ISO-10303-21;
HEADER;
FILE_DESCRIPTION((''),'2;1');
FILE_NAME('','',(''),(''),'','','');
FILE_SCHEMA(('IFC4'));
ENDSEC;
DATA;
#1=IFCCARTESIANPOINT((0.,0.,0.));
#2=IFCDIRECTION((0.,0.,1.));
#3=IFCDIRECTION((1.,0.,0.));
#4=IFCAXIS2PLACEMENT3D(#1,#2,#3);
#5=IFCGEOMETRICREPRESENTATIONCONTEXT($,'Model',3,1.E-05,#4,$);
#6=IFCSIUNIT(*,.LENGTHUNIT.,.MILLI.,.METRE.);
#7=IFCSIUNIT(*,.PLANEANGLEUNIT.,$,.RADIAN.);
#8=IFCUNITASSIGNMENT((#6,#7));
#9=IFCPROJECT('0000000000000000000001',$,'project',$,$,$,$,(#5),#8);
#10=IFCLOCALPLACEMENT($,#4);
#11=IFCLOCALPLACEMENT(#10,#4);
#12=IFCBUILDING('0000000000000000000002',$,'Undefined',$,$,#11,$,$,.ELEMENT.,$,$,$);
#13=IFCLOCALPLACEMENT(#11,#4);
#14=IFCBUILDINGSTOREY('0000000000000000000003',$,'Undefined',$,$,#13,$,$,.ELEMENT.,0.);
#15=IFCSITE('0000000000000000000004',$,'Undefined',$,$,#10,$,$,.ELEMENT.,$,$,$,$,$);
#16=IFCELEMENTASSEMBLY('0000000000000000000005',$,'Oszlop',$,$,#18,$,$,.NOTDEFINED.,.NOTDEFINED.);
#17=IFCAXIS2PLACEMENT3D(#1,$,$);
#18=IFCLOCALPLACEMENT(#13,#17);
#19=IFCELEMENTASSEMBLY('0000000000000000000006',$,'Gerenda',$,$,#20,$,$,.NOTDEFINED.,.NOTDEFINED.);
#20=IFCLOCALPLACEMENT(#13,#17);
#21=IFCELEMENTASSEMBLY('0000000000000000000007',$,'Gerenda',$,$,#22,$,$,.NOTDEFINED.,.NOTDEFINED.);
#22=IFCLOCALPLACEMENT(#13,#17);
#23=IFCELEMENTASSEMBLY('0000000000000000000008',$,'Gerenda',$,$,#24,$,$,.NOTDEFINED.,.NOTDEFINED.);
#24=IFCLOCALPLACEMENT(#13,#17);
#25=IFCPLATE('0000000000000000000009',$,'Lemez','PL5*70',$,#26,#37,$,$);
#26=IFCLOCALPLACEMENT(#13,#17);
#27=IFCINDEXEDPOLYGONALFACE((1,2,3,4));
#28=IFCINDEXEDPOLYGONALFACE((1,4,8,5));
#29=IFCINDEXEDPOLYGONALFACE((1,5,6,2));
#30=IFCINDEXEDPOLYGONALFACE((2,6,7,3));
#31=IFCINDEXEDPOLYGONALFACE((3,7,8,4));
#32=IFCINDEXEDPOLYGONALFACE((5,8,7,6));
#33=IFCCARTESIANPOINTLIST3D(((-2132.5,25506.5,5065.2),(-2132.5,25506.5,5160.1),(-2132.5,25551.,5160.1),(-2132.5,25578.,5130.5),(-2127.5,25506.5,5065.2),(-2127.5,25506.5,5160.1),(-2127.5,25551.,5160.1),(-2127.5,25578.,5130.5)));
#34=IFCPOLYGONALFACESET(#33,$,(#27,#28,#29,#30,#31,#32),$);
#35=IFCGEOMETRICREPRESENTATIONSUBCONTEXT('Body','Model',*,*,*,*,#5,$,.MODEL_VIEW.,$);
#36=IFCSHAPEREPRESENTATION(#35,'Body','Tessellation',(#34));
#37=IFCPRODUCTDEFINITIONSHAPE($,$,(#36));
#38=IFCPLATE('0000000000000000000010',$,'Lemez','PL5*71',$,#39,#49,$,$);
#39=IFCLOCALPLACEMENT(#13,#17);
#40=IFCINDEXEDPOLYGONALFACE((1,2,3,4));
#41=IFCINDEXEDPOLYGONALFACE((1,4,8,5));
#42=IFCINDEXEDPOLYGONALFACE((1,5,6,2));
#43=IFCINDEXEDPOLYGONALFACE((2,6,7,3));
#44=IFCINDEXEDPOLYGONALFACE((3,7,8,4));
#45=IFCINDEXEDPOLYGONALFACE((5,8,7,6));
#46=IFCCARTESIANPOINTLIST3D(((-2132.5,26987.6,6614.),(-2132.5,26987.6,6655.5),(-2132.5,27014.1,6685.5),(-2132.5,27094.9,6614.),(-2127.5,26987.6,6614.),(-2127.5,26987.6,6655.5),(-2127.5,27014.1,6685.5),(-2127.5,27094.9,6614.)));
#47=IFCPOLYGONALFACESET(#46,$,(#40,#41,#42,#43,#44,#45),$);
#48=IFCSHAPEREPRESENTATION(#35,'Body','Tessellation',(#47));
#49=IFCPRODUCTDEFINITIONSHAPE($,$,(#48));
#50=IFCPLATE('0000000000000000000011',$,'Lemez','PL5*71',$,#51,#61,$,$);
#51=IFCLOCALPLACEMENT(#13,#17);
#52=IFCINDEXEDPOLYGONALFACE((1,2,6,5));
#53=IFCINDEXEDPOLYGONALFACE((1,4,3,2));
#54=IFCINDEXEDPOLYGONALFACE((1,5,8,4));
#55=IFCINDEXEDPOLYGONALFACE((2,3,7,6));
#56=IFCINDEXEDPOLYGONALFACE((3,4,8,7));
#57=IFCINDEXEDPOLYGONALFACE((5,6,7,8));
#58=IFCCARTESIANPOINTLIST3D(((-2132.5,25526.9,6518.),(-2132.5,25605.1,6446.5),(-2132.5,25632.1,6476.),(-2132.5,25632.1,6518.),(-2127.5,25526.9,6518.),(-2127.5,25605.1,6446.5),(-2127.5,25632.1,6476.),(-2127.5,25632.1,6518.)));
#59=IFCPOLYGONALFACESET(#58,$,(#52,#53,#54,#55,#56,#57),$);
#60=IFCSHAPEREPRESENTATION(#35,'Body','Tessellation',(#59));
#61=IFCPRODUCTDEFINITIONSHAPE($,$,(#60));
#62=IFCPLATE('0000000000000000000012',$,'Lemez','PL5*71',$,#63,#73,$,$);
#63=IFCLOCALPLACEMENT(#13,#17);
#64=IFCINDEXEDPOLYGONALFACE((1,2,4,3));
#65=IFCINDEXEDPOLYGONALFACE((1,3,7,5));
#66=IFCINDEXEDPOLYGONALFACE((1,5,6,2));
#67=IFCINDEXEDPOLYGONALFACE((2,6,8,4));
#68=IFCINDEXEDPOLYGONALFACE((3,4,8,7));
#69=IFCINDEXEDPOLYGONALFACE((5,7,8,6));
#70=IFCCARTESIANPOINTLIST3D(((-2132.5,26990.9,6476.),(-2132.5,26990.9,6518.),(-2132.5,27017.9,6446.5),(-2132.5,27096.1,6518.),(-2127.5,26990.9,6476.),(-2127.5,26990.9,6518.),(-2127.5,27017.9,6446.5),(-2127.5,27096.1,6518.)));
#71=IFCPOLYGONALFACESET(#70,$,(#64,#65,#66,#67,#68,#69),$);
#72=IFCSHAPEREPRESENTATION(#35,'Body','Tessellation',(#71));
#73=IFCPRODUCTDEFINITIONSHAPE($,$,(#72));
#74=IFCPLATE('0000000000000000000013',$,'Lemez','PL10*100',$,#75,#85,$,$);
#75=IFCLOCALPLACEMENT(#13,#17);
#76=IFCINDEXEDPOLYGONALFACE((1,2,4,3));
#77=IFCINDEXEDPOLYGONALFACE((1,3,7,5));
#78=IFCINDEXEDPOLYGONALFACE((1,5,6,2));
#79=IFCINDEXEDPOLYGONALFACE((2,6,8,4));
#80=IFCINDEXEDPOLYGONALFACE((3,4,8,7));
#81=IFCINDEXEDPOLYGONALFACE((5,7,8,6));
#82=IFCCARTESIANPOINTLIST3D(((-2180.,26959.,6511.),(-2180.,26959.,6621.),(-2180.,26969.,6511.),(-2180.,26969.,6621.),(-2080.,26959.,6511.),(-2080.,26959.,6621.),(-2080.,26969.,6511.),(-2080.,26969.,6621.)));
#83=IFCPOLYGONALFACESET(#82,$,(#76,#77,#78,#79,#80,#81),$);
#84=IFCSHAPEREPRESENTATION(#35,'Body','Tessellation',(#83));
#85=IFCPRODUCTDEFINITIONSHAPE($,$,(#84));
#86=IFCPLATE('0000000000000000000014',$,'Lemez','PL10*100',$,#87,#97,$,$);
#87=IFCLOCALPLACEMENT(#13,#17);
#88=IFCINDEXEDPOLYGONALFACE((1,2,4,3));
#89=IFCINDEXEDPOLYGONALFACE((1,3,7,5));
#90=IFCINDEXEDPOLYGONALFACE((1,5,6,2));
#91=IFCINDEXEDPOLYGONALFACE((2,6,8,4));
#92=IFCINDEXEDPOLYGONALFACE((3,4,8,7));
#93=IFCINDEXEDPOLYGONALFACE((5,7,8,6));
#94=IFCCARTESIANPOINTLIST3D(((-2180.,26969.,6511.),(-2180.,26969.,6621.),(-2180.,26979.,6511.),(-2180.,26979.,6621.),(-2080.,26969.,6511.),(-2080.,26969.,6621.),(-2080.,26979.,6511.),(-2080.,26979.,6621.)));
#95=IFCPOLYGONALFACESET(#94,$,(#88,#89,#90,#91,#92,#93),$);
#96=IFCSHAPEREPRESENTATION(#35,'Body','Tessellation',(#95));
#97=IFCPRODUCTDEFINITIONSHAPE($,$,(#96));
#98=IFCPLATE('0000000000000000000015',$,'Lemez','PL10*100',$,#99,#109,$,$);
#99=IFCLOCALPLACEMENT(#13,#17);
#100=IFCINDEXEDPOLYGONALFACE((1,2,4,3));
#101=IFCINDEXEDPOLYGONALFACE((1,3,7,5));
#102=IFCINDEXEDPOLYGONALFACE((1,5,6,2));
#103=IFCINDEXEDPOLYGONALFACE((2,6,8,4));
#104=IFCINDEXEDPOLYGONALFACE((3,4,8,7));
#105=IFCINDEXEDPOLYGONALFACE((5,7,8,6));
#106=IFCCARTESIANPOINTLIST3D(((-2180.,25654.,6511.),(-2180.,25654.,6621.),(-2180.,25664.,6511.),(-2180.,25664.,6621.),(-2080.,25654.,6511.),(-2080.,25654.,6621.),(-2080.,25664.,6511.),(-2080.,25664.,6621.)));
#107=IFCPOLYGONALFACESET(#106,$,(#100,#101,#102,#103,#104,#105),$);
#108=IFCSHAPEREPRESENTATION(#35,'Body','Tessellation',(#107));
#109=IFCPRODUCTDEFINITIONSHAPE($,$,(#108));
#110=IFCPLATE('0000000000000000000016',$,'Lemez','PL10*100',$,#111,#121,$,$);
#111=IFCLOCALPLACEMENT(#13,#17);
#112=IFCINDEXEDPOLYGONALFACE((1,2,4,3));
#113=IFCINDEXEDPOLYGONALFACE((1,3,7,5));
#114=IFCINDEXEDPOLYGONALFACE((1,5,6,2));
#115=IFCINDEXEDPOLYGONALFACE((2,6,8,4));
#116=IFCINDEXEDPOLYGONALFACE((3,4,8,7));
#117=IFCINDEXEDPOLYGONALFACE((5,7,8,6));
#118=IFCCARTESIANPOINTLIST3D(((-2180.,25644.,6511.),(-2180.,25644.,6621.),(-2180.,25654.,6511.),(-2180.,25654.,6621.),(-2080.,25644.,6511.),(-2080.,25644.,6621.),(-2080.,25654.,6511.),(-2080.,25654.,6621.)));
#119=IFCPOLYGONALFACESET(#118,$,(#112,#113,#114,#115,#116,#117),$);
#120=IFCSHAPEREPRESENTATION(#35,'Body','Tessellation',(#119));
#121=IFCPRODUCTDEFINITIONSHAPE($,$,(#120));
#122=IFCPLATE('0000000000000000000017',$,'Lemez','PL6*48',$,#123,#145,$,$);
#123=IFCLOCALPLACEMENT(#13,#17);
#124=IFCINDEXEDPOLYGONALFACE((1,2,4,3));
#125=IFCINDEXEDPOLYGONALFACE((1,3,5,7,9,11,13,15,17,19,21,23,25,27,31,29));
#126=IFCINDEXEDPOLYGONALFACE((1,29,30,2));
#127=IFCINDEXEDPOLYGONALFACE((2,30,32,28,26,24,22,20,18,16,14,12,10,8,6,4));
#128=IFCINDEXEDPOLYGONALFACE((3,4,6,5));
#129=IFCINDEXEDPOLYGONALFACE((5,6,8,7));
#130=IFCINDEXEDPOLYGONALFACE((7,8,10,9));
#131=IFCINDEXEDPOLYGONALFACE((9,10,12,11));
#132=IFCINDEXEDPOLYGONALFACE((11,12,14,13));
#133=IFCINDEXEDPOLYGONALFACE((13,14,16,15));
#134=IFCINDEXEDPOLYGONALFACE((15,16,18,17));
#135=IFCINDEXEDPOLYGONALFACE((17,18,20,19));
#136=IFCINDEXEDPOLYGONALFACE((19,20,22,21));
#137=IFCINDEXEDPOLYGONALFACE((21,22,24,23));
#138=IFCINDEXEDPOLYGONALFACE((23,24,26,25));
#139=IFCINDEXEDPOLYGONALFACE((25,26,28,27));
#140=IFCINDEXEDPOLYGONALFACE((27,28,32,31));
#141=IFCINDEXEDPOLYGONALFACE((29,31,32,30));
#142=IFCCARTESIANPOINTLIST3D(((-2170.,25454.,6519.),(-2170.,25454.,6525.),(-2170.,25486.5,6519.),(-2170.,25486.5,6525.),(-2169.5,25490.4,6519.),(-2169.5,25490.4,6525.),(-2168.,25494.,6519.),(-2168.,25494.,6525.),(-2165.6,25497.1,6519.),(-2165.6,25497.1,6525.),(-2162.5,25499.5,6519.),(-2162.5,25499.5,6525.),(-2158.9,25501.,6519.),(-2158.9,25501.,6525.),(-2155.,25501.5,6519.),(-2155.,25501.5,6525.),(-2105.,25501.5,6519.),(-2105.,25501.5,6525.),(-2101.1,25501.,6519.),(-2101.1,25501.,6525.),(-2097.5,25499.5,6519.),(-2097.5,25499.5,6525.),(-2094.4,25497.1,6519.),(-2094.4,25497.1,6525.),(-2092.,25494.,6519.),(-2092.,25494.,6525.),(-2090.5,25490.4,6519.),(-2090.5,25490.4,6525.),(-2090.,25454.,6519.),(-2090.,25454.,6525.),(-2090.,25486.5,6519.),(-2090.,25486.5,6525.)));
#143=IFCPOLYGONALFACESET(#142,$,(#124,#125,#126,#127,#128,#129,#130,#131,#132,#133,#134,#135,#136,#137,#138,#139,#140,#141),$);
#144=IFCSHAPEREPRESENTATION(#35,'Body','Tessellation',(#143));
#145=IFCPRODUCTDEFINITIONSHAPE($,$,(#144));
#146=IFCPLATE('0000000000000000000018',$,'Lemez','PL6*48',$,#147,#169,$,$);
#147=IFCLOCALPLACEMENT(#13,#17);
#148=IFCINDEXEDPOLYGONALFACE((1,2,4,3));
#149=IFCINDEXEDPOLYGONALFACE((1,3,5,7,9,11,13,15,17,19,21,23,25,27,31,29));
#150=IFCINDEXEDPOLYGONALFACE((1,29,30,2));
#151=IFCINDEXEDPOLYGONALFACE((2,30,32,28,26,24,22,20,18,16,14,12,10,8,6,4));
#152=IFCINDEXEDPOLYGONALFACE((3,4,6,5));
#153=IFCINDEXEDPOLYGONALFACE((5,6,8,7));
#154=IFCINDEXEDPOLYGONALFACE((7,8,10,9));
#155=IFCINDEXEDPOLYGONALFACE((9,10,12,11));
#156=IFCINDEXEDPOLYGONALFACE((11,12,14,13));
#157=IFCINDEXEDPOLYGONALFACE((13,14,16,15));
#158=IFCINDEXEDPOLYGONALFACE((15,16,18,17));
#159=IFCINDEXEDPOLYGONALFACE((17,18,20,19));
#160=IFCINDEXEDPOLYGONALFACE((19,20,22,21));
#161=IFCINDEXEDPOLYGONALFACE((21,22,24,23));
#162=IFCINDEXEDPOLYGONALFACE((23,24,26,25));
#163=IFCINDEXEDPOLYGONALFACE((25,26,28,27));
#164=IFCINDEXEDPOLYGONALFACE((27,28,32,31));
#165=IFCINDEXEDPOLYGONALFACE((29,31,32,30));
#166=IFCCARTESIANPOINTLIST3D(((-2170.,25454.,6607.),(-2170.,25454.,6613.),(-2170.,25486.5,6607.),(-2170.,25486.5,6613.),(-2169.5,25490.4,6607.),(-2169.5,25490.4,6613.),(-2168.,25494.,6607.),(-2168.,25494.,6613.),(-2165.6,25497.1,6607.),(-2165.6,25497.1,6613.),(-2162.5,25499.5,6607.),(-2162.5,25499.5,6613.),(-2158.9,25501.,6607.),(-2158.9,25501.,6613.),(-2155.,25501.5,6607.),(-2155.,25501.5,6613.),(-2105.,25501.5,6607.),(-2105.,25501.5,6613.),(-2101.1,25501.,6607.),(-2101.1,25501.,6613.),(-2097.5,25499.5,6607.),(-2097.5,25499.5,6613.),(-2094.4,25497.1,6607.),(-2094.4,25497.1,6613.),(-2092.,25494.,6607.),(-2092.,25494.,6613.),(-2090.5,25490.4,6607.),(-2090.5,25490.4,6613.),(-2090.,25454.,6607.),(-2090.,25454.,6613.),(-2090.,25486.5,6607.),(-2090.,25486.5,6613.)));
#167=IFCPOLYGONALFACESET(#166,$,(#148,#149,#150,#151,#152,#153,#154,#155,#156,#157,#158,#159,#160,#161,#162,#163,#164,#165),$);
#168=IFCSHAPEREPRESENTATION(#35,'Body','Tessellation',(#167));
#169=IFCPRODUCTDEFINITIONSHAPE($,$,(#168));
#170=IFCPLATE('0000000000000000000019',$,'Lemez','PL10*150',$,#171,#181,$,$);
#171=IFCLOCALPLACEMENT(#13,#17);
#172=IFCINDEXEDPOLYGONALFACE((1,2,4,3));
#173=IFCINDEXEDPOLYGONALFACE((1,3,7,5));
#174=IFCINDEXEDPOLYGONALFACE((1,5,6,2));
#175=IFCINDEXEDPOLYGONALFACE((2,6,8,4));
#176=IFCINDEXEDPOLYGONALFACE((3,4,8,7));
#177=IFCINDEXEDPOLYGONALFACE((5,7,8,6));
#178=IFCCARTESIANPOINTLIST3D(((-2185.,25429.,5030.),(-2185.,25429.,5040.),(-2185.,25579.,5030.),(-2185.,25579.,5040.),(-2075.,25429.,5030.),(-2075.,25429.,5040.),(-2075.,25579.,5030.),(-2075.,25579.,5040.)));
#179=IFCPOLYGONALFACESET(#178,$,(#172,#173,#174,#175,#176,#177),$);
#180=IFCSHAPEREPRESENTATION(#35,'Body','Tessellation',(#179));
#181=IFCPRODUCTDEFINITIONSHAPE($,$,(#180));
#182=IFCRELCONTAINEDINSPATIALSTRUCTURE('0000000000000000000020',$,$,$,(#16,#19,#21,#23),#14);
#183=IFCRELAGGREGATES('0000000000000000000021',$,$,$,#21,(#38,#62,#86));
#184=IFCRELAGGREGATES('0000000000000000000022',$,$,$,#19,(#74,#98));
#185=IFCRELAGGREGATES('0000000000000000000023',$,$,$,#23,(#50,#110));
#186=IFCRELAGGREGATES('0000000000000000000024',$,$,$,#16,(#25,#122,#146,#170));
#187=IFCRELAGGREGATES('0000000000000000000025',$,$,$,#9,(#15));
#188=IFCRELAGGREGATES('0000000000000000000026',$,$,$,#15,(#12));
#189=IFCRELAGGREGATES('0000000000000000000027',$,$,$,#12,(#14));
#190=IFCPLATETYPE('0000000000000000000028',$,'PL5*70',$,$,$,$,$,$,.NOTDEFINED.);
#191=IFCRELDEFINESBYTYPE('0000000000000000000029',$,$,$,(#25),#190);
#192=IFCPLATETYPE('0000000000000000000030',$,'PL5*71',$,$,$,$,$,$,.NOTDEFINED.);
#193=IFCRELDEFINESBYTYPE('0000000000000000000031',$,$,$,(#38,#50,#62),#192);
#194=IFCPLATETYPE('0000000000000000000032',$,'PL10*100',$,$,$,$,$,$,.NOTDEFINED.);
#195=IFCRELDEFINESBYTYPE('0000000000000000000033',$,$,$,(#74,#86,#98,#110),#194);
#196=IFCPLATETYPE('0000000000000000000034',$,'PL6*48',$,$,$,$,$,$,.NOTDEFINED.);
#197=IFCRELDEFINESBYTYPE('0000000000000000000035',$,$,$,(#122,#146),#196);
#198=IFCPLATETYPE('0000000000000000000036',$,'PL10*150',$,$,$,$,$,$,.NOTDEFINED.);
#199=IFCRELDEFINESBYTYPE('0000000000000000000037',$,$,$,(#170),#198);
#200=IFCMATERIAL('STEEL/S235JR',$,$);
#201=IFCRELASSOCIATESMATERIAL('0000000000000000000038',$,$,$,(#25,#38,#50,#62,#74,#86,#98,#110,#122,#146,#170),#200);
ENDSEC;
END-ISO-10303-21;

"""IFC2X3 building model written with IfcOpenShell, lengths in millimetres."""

from ifc_helpers import new_model, si_unit, frame, frame_2d, origin_with_axes, place, context, subcontext, project, spatial, polyline, circle_curve, parameter, trimmed, segment, composite_curve, outline, extrude, material, type_object, element, aggregate, save


model = new_model("IFC2X3")

# Units and contexts
model_context = context("Model", 3, precision=1e-05, world=origin_with_axes())
body_context = subcontext(model_context, "Body", "Model", "MODEL_VIEW")
ifc_project = project(units=[si_unit("LENGTHUNIT", "METRE", prefix="MILLI"), si_unit("PLANEANGLEUNIT", "RADIAN")], contexts=[model_context])

# Site, building, storey
site_placement = place(None, origin_with_axes())
site = spatial("IfcSite", under=ifc_project, at=site_placement, Name="Undefined", CompositionType="ELEMENT")
building_placement = place(site_placement, origin_with_axes())
building = spatial("IfcBuilding", under=site, at=building_placement, Name="Undefined", CompositionType="ELEMENT")
storey_placement = place(building_placement, origin_with_axes())
storey = spatial("IfcBuildingStorey", under=building, at=storey_placement, Name="Undefined", CompositionType="ELEMENT", Elevation=0.0)

# Element assembly
assembly_1_placement = place(storey_placement, origin_with_axes())
assembly_1 = element("IfcElementAssembly", 1, at=assembly_1_placement, inside=storey, Name="Oszlop", AssemblyPlace="NOTDEFINED", PredefinedType="NOTDEFINED")
ifc_material_1 = material(Name="STEEL/S235JR")

# Element assemblies
assembly_2_placement = place(storey_placement, origin_with_axes())
assembly_2 = element("IfcElementAssembly", 2, at=assembly_2_placement, inside=storey, Name="Gerenda", AssemblyPlace="NOTDEFINED", PredefinedType="NOTDEFINED")
assembly_3_placement = place(storey_placement, origin_with_axes())
assembly_3 = element("IfcElementAssembly", 3, at=assembly_3_placement, inside=storey, Name="Gerenda", AssemblyPlace="NOTDEFINED", PredefinedType="NOTDEFINED")
assembly_4_placement = place(storey_placement, origin_with_axes())
assembly_4 = element("IfcElementAssembly", 4, at=assembly_4_placement, inside=storey, Name="Gerenda", AssemblyPlace="NOTDEFINED", PredefinedType="NOTDEFINED")

# Plates
plate_type_1 = type_object("IfcPlateType", Name="PL5*70", PredefinedType="NOTDEFINED")
plate_1_placement = place(assembly_1_placement, frame((-2130.0, 25506.5, 5160.1), z_axis=(1.0, -0.000004, 0.0), x_axis=(0.0, 0.0, -1.0)))
plate_1 = element("IfcPlate", 5, at=plate_1_placement, type_object=plate_type_1, material=ifc_material_1, Name="Lemez", Description="PL5*70", context=body_context, shape_type="SweptSolid", body=[
    extrude(outline(polyline([(0.0, 0.0), (94.9, 0.0), (29.5, 71.5), (0.0, 44.5), (0.0, 0.0)])), frame((0.0, 0.0, -2.5), z_axis=(0.0, 0.0, 1.0), x_axis=(1.0, 0.0, 0.0)), (0.0, 0.0, 1.0), 5.0),
])
plate_type_2 = type_object("IfcPlateType", Name="PL5*71", PredefinedType="NOTDEFINED")
plate_2_placement = place(assembly_3_placement, frame((-2130.0, 27094.9, 6614.0), z_axis=(-1.0, -0.000003, 0.000002), x_axis=(0.000003, -1.0, 0.0)))
plate_2 = element("IfcPlate", 6, at=plate_2_placement, type_object=plate_type_2, material=ifc_material_1, Name="Lemez", Description="PL5*71", context=body_context, shape_type="SweptSolid", body=[
    extrude(outline(polyline([(0.0, 0.0), (107.3, 0.0), (107.3, 41.5), (80.8, 71.5), (0.0, 0.0)])), frame((0.0, 0.0, -2.5), z_axis=(0.0, 0.0, 1.0), x_axis=(1.0, 0.0, 0.0)), (0.0, 0.0, 1.0), 5.0),
])
plate_3_placement = place(assembly_4_placement, frame((-2130.0, 25526.9, 6518.0), z_axis=(-1.0, -0.000003, 0.000002), x_axis=(-0.000003, 1.0, 0.0)))
plate_3 = element("IfcPlate", 7, at=plate_3_placement, type_object=plate_type_2, material=ifc_material_1, Name="Lemez", Description="PL5*71", context=body_context, shape_type="SweptSolid", body=[
    extrude(outline(polyline([(0.0, 0.0), (105.2, 0.0), (105.2, 42.0), (78.2, 71.5), (0.0, 0.0)])), frame((0.0, 0.0, -2.5), z_axis=(0.0, 0.0, 1.0), x_axis=(1.0, 0.0, 0.0)), (0.0, 0.0, 1.0), 5.0),
])
plate_4_placement = place(assembly_3_placement, frame((-2130.0, 27096.1, 6518.0), z_axis=(1.0, -0.000003, -0.000002), x_axis=(-0.000003, -1.0, 0.0)))
plate_4 = element("IfcPlate", 8, at=plate_4_placement, type_object=plate_type_2, material=ifc_material_1, Name="Lemez", Description="PL5*71", context=body_context, shape_type="SweptSolid", body=[
    extrude(outline(polyline([(0.0, 0.0), (105.2, 0.0), (105.2, 42.0), (78.2, 71.5), (0.0, 0.0)])), frame((0.0, 0.0, -2.5), z_axis=(0.0, 0.0, 1.0), x_axis=(1.0, 0.0, 0.0)), (0.0, 0.0, 1.0), 5.0),
])
plate_type_3 = type_object("IfcPlateType", Name="PL10*100", PredefinedType="NOTDEFINED")
plate_5_placement = place(assembly_2_placement, frame((-2130.0, 26964.0, 6511.0), z_axis=(-0.000003, -1.0, 0.0), x_axis=(0.0, 0.0, 1.0)))
plate_5 = element("IfcPlate", 9, at=plate_5_placement, type_object=plate_type_3, material=ifc_material_1, Name="Lemez", Description="PL10*100", context=body_context, shape_type="SweptSolid", body=[
    extrude(outline(polyline([(0.0, -50.0), (0.0, 50.0), (110.0, 50.0), (110.0, -50.0), (0.0, -50.0)])), frame((0.0, 0.0, -5.0), z_axis=(0.0, 0.0, 1.0), x_axis=(1.0, 0.0, 0.0)), (0.0, 0.0, 1.0), 10.0),
])
plate_6_placement = place(assembly_3_placement, frame((-2130.0, 26974.0, 6511.0), z_axis=(-0.000003, -1.0, 0.0), x_axis=(0.0, 0.0, 1.0)))
plate_6 = element("IfcPlate", 10, at=plate_6_placement, type_object=plate_type_3, material=ifc_material_1, Name="Lemez", Description="PL10*100", context=body_context, shape_type="SweptSolid", body=[
    extrude(outline(polyline([(0.0, -50.0), (0.0, 50.0), (110.0, 50.0), (110.0, -50.0), (0.0, -50.0)])), frame((0.0, 0.0, -5.0), z_axis=(0.0, 0.0, 1.0), x_axis=(1.0, 0.0, 0.0)), (0.0, 0.0, 1.0), 10.0),
])
aggregate(assembly_3, [plate_2, plate_4, plate_6])
plate_7_placement = place(assembly_2_placement, frame((-2130.0, 25659.0, 6511.0), z_axis=(0.000003, 1.0, 0.0), x_axis=(0.0, 0.0, 1.0)))
plate_7 = element("IfcPlate", 11, at=plate_7_placement, type_object=plate_type_3, material=ifc_material_1, Name="Lemez", Description="PL10*100", context=body_context, shape_type="SweptSolid", body=[
    extrude(outline(polyline([(0.0, -50.0), (0.0, 50.0), (110.0, 50.0), (110.0, -50.0), (0.0, -50.0)])), frame((0.0, 0.0, -5.0), z_axis=(0.0, 0.0, 1.0), x_axis=(1.0, 0.0, 0.0)), (0.0, 0.0, 1.0), 10.0),
])
aggregate(assembly_2, [plate_5, plate_7])
plate_8_placement = place(assembly_4_placement, frame((-2130.0, 25649.0, 6511.0), z_axis=(0.000003, 1.0, 0.0), x_axis=(0.0, 0.0, 1.0)))
plate_8 = element("IfcPlate", 12, at=plate_8_placement, type_object=plate_type_3, material=ifc_material_1, Name="Lemez", Description="PL10*100", context=body_context, shape_type="SweptSolid", body=[
    extrude(outline(polyline([(0.0, -50.0), (0.0, 50.0), (110.0, 50.0), (110.0, -50.0), (0.0, -50.0)])), frame((0.0, 0.0, -5.0), z_axis=(0.0, 0.0, 1.0), x_axis=(1.0, 0.0, 0.0)), (0.0, 0.0, 1.0), 10.0),
])
aggregate(assembly_4, [plate_3, plate_8])
plate_type_4 = type_object("IfcPlateType", Name="PL6*48", PredefinedType="NOTDEFINED")
plate_9_placement = place(assembly_1_placement, frame((-2090.0, 25454.0, 6522.0), z_axis=(0.0, 0.0, -1.0), x_axis=(-1.0, 0.0, 0.0)))
plate_9 = element("IfcPlate", 13, at=plate_9_placement, type_object=plate_type_4, material=ifc_material_1, Name="Lemez", Description="PL6*48", context=body_context, shape_type="SweptSolid", body=[
    extrude(outline(composite_curve([segment(polyline([(0.0, 0.0), (80.0, 0.0), (80.0, 32.5)]), True, "CONTINUOUS"), segment(trimmed(circle_curve(frame_2d((65.0, 32.5), x_axis=(1.0, 0.0)), 15.0), [parameter(0.0)], [parameter(1.570796)], True, "PARAMETER"), True, "CONTINUOUS"), segment(polyline([(65.0, 47.5), (15.0, 47.5)]), True, "CONTINUOUS"), segment(trimmed(circle_curve(frame_2d((15.0, 32.5), x_axis=(0.0, 1.0)), 15.0), [parameter(0.0)], [parameter(1.570796)], True, "PARAMETER"), True, "CONTINUOUS"), segment(polyline([(0.0, 32.5), (0.0, 0.0)]), True, "CONTINUOUS")], self_intersect=True)), frame((0.0, 0.0, -3.0), z_axis=(0.0, 0.0, 1.0), x_axis=(1.0, 0.0, 0.0)), (0.0, 0.0, 1.0), 6.0),
])
plate_10_placement = place(assembly_1_placement, frame((-2090.0, 25454.0, 6610.0), z_axis=(0.0, 0.0, 1.0), x_axis=(0.0, 1.0, 0.0)))
plate_10 = element("IfcPlate", 14, at=plate_10_placement, type_object=plate_type_4, material=ifc_material_1, Name="Lemez", Description="PL6*48", context=body_context, shape_type="SweptSolid", body=[
    extrude(outline(composite_curve([segment(polyline([(0.0, 0.0), (32.5, 0.0)]), True, "CONTINUOUS"), segment(trimmed(circle_curve(frame_2d((32.5, 15.0), x_axis=(0.0, -1.0)), 15.0), [parameter(0.0)], [parameter(1.570796)], True, "PARAMETER"), True, "CONTINUOUS"), segment(polyline([(47.5, 15.0), (47.5, 65.0)]), True, "CONTINUOUS"), segment(trimmed(circle_curve(frame_2d((32.5, 65.0), x_axis=(1.0, 0.0)), 15.0), [parameter(0.0)], [parameter(1.570796)], True, "PARAMETER"), True, "CONTINUOUS"), segment(polyline([(32.5, 80.0), (0.0, 80.0), (0.0, 0.0)]), True, "CONTINUOUS")], self_intersect=True)), frame((0.0, 0.0, -3.0), z_axis=(0.0, 0.0, 1.0), x_axis=(1.0, 0.0, 0.0)), (0.0, 0.0, 1.0), 6.0),
])
plate_type_5 = type_object("IfcPlateType", Name="PL10*150", PredefinedType="NOTDEFINED")
plate_11_placement = place(assembly_1_placement, frame((-2075.0, 25504.0, 5035.0), z_axis=(0.0, 0.0, 1.0), x_axis=(-1.0, 0.0, 0.0)))
plate_11 = element("IfcPlate", 15, at=plate_11_placement, type_object=plate_type_5, material=ifc_material_1, Name="Lemez", Description="PL10*150", context=body_context, shape_type="SweptSolid", body=[
    extrude(outline(polyline([(0.0, -75.0), (0.0, 75.0), (110.0, 75.0), (110.0, -75.0), (0.0, -75.0)])), frame((0.0, 0.0, -5.0), z_axis=(0.0, 0.0, 1.0), x_axis=(1.0, 0.0, 0.0)), (0.0, 0.0, 1.0), 10.0),
])

aggregate(assembly_1, [plate_1, plate_9, plate_10, plate_11])

save(model, "model.ifc")
